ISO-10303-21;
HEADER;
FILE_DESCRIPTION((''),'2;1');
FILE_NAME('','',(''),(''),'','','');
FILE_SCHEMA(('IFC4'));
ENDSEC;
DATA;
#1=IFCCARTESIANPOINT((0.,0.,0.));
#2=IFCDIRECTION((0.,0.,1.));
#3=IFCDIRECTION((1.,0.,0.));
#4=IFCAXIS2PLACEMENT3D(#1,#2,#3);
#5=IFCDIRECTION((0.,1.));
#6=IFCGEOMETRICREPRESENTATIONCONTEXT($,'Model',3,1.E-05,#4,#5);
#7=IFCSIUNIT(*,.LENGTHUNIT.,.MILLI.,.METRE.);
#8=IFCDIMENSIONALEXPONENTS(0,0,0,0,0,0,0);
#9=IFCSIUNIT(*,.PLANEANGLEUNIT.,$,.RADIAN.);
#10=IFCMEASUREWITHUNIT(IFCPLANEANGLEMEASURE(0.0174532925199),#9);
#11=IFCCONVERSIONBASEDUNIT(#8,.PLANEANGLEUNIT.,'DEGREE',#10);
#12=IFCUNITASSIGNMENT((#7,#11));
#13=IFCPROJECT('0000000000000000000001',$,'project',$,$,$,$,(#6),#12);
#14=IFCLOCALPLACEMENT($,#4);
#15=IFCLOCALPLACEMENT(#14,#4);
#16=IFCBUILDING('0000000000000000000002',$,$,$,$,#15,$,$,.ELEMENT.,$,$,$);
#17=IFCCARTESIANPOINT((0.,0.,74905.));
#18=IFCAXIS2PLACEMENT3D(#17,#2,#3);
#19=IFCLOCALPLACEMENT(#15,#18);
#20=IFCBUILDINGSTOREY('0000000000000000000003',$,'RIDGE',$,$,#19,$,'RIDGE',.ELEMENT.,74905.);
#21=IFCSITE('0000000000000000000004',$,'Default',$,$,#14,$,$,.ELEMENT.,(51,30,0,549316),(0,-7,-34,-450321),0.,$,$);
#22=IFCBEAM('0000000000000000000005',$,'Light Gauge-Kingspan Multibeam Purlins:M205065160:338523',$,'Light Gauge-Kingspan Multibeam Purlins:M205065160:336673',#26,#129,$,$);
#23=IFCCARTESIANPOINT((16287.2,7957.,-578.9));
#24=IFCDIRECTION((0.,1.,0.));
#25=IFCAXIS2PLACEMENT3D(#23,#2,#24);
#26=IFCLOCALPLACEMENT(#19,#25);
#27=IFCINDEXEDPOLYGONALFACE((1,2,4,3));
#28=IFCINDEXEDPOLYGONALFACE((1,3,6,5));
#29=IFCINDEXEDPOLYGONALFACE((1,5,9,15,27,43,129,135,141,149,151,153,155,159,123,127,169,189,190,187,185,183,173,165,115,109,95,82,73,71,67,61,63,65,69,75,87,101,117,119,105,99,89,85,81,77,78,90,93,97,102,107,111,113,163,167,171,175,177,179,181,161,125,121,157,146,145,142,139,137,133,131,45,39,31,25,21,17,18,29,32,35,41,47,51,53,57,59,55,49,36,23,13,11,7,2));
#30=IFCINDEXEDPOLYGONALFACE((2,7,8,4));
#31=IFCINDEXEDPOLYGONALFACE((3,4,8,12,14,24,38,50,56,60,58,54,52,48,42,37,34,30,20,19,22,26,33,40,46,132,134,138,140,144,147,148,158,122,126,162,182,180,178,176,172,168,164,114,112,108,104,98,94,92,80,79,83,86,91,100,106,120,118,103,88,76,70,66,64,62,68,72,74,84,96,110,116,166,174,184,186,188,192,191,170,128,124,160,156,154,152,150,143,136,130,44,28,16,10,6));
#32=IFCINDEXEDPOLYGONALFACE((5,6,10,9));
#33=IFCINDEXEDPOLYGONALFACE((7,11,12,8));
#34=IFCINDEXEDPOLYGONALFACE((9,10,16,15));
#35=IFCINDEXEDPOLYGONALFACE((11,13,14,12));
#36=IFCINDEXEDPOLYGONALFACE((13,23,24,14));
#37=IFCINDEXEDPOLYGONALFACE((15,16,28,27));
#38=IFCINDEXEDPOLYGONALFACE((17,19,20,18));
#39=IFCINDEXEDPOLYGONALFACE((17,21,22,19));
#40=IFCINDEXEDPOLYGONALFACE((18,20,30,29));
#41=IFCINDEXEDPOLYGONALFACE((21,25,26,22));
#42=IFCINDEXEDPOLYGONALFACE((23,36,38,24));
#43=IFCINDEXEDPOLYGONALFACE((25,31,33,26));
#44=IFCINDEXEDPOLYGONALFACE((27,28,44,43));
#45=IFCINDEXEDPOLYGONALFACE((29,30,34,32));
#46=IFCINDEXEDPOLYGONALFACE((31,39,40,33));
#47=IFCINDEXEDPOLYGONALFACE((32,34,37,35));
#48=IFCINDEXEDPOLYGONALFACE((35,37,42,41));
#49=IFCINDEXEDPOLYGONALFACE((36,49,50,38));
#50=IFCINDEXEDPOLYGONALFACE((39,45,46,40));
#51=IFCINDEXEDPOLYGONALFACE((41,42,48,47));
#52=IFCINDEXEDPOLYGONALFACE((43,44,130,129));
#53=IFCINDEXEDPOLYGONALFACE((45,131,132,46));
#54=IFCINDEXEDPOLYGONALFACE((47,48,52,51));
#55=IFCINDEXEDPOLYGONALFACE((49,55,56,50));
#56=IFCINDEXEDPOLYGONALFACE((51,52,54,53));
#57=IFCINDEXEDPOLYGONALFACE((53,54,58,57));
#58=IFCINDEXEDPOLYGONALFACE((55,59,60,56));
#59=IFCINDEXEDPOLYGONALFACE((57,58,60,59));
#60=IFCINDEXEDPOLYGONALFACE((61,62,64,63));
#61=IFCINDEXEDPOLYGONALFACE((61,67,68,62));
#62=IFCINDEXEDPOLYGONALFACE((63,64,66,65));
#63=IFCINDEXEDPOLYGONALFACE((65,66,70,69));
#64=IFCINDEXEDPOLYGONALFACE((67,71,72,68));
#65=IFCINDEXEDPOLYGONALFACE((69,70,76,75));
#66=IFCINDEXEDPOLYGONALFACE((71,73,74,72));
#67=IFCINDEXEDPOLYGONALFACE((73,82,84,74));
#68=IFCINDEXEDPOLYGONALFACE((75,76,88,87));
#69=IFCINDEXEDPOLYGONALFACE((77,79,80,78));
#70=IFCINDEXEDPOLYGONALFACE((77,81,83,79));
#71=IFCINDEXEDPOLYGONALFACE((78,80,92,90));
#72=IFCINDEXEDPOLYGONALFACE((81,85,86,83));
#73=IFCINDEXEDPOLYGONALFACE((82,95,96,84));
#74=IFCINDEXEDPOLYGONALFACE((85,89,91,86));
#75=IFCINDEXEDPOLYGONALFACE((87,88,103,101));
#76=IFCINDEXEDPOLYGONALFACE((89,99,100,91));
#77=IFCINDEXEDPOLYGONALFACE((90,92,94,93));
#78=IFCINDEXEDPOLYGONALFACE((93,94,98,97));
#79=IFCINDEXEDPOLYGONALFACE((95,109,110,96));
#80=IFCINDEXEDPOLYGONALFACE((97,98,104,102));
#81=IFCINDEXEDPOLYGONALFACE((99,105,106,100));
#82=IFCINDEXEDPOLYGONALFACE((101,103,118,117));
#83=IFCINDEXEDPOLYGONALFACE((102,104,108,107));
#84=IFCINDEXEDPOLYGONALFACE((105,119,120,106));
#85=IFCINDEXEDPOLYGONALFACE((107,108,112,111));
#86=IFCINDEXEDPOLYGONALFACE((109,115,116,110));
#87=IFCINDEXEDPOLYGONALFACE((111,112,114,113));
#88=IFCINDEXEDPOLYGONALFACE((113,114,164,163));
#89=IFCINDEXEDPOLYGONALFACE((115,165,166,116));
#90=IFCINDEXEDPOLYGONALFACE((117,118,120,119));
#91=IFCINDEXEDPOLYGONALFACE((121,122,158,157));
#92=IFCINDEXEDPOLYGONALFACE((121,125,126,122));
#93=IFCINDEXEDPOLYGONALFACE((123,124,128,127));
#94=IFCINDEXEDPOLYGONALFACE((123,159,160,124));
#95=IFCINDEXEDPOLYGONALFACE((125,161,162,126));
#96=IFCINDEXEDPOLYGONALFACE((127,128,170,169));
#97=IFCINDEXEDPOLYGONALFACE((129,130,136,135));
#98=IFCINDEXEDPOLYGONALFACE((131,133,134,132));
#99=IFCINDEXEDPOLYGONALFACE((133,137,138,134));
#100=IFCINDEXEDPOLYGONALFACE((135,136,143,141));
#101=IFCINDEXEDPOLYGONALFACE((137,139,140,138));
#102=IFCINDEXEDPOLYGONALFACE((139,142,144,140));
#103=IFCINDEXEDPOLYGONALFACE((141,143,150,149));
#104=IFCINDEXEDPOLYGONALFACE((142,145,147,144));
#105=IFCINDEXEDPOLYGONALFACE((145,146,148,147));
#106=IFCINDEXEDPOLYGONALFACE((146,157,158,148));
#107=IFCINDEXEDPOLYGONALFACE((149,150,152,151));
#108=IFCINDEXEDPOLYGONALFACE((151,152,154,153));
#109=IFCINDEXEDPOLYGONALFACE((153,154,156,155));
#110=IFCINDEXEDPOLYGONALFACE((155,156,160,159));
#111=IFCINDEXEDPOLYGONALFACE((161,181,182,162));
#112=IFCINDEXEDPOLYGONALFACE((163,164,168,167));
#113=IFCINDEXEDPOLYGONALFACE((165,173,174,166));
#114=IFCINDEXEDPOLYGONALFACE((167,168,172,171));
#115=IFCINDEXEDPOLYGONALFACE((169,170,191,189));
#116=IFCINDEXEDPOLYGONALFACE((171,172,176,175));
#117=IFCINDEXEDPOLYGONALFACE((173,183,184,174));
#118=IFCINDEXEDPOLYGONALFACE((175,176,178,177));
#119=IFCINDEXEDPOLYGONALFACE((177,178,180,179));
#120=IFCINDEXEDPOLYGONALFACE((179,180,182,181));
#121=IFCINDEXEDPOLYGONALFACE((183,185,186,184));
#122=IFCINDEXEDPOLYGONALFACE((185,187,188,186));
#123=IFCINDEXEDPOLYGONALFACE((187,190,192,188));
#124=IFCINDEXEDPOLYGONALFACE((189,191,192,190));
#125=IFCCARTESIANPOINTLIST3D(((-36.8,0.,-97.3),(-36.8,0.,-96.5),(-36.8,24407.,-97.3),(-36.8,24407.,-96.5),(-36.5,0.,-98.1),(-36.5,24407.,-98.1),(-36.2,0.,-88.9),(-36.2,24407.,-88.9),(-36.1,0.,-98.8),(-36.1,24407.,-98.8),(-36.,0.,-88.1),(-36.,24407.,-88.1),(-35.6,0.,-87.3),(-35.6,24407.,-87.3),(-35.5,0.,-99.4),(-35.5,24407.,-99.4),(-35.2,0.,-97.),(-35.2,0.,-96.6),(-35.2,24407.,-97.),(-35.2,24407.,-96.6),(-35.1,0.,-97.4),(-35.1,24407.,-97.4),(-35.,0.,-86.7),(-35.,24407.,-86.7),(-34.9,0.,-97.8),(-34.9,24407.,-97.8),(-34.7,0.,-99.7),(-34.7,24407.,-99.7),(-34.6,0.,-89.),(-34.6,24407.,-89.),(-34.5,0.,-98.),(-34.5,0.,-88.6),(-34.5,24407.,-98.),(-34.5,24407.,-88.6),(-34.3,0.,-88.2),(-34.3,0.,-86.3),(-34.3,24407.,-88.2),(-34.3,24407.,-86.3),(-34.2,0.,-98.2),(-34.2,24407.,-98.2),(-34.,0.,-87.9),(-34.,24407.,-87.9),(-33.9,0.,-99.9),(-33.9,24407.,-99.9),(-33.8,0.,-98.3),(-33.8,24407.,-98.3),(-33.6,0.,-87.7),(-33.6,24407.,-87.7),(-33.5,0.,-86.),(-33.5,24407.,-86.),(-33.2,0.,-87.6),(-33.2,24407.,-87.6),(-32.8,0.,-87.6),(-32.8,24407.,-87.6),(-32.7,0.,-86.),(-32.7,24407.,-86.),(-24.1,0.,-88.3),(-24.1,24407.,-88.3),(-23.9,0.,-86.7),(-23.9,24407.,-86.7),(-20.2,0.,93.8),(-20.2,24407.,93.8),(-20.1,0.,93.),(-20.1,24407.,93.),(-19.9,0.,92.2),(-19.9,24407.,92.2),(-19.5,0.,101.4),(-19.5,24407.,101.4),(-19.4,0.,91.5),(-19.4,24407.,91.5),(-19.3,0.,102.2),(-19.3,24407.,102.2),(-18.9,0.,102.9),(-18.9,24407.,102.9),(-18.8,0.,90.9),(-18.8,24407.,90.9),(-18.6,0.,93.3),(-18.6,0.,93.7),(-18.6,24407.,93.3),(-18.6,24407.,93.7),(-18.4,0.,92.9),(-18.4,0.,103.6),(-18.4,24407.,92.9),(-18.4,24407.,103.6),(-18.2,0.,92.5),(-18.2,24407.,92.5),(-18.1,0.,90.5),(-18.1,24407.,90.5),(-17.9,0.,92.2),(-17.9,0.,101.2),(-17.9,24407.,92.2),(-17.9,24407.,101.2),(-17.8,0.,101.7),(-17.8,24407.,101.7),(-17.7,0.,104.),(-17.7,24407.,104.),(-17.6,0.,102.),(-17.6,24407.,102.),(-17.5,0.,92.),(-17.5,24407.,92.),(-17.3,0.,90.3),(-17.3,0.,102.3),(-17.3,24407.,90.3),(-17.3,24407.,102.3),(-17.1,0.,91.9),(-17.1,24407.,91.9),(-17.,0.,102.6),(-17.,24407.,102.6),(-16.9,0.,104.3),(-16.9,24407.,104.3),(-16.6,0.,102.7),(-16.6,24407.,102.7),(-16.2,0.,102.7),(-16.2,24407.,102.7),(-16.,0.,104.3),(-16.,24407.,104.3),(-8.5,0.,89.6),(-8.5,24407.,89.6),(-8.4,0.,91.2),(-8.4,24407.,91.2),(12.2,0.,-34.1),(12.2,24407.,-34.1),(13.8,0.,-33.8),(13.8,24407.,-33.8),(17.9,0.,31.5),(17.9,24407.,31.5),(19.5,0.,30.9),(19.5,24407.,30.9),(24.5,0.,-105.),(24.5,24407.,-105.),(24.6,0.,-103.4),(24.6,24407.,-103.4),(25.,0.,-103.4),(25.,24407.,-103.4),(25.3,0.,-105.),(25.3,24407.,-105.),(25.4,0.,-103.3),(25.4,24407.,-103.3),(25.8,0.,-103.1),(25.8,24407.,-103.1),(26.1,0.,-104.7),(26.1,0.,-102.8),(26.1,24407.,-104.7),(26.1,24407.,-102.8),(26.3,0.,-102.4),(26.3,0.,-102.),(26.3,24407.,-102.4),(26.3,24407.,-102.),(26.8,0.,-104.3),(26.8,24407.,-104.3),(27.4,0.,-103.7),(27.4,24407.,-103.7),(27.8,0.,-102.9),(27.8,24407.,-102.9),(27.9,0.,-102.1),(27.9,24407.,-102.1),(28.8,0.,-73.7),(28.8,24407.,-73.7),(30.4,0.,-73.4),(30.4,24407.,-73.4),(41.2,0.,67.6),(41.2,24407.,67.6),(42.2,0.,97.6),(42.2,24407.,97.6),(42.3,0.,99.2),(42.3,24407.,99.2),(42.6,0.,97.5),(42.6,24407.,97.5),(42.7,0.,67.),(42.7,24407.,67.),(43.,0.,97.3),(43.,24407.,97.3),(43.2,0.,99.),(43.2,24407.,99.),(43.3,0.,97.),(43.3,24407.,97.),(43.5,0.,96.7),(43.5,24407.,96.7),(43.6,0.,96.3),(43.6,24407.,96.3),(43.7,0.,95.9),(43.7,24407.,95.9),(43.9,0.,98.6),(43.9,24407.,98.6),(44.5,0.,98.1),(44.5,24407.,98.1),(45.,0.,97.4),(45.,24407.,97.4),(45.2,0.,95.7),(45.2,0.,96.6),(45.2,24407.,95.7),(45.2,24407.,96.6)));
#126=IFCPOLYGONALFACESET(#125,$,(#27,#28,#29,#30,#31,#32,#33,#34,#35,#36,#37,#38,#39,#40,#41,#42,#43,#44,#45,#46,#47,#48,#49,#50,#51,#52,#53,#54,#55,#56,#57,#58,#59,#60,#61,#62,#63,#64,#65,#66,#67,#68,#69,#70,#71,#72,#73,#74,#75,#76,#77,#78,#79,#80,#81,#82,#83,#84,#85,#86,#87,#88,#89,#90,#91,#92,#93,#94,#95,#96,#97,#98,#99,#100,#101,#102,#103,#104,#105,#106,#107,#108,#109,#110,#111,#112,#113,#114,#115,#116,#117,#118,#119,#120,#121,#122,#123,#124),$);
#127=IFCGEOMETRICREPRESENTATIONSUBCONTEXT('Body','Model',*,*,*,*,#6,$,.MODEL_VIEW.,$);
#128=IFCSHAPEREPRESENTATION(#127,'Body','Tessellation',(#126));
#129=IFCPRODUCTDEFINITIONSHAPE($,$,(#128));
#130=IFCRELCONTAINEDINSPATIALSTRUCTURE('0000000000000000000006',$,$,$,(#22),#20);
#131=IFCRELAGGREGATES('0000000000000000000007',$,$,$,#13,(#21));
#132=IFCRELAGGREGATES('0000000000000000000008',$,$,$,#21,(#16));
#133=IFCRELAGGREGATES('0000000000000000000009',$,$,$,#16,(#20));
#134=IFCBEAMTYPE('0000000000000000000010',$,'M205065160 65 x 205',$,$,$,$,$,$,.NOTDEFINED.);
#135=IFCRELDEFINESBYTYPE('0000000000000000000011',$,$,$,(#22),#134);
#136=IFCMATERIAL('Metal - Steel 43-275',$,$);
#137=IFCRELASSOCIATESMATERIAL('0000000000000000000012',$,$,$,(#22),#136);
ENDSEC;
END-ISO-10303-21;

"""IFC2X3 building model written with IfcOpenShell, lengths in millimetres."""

from ifc_helpers import new_model, entity, si_unit, converted_unit, point, direction, frame, frame_2d, origin_with_axes, place, context, subcontext, project, spatial, polyline, circle_curve, parameter, trimmed, segment, composite_curve, outline, extrude, material, type_object, element, save


model = new_model("IFC2X3")

# Units and contexts
model_context = context("Model", 3, precision=1e-05, world=origin_with_axes(), true_north=direction((0.0, 1.0)))
body_context = subcontext(model_context, "Body", "Model", "MODEL_VIEW")
ifc_project = project(units=[si_unit("LENGTHUNIT", "METRE", prefix="MILLI"), converted_unit("PLANEANGLEUNIT", "DEGREE", entity("IfcPlaneAngleMeasure", 0.0174532925199), si_unit("PLANEANGLEUNIT", "RADIAN"), dimensions=[0, 0, 0, 0, 0, 0, 0])], contexts=[model_context])

# Site, building, storey
site_placement = place(None, origin_with_axes())
site = spatial("IfcSite", under=ifc_project, at=site_placement, Name="Default", CompositionType="ELEMENT", RefLatitude=(51, 30, 0, 549316), RefLongitude=(0, -7, -34, -450321), RefElevation=0.0)
building_placement = place(site_placement, origin_with_axes())
building = spatial("IfcBuilding", under=site, at=building_placement, CompositionType="ELEMENT")
storey_placement = place(building_placement, frame((0.0, 0.0, 74905.0), z_axis=(0.0, 0.0, 1.0), x_axis=(1.0, 0.0, 0.0)))
storey = spatial("IfcBuildingStorey", under=building, at=storey_placement, Name="RIDGE", LongName="RIDGE", CompositionType="ELEMENT", Elevation=74905.0)

# Beam
ifc_material_1 = material(Name="Metal - Steel 43-275")
beam_type_1 = type_object("IfcBeamType", Name="M205065160 65 x 205", PredefinedType="NOTDEFINED")
beam_1_placement = place(storey_placement, frame((16287.2, 7957.0, -578.9), z_axis=(0.0, 0.0, 1.0), x_axis=(0.0, 1.0, 0.0)))
element("IfcBeam", 1, at=beam_1_placement, inside=storey, type_object=beam_type_1, material=ifc_material_1, Name="Light Gauge-Kingspan Multibeam Purlins:M205065160:338523", ObjectType="Light Gauge-Kingspan Multibeam Purlins:M205065160:336673", context=body_context, shape_type="SweptSolid", body=[
    extrude(outline(composite_curve([segment(polyline([(-33.5, -102.5), (25.1, -102.5)]), True, "CONTINUOUS"), segment(trimmed(circle_curve(frame_2d((25.1, -99.3), x_axis=(0.0, -1.0)), 3.2), [point((25.1, -102.5)), parameter(0.0)], [point((28.3, -99.3)), parameter(90.0)], True, "CARTESIAN"), True, "CONTINUOUS"), segment(polyline([(28.3, -99.3), (28.3, -91.7)]), True, "CONTINUOUS"), segment(trimmed(circle_curve(frame_2d((25.1, -91.7), x_axis=(1.0, 0.0)), 3.2), [point((28.3, -91.7)), parameter(0.0)], [point((25.1, -88.5)), parameter(90.0)], True, "CARTESIAN"), True, "CONTINUOUS"), segment(polyline([(25.1, -88.5), (16.3, -88.5), (16.3, -90.1), (25.1, -90.1)]), True, "CONTINUOUS"), segment(trimmed(circle_curve(frame_2d((25.1, -91.7), x_axis=(1.0, 0.0)), 1.6), [point((25.1, -90.1)), parameter(90.0)], [point((26.7, -91.7)), parameter(0.0)], False, "CARTESIAN"), True, "CONTINUOUS"), segment(polyline([(26.7, -91.7), (26.7, -99.3)]), True, "CONTINUOUS"), segment(trimmed(circle_curve(frame_2d((25.1, -99.3), x_axis=(0.0, -1.0)), 1.6), [point((26.7, -99.3)), parameter(90.0)], [point((25.1, -100.9)), parameter(0.0)], False, "CARTESIAN"), True, "CONTINUOUS"), segment(polyline([(25.1, -100.9), (-33.5, -100.9)]), True, "CONTINUOUS"), segment(trimmed(circle_curve(frame_2d((-33.5, -99.3), x_axis=(-1.0, 0.0)), 1.6), [point((-33.5, -100.9)), parameter(90.0)], [point((-35.1, -99.3)), parameter(0.0)], False, "CARTESIAN"), True, "CONTINUOUS"), segment(polyline([(-35.1, -99.3), (-35.1, -70.9), (-15.1, -32.9), (-15.1, 32.9), (-35.1, 70.9), (-35.1, 99.3)]), True, "CONTINUOUS"), segment(trimmed(circle_curve(frame_2d((-33.5, 99.3), x_axis=(0.0, 1.0)), 1.6), [point((-35.1, 99.3)), parameter(90.0)], [point((-33.5, 100.9)), parameter(0.0)], False, "CARTESIAN"), True, "CONTINUOUS"), segment(polyline([(-33.5, 100.9), (25.1, 100.9)]), True, "CONTINUOUS"), segment(trimmed(circle_curve(frame_2d((25.1, 99.3), x_axis=(1.0, 0.0)), 1.6), [point((25.1, 100.9)), parameter(90.0)], [point((26.7, 99.3)), parameter(0.0)], False, "CARTESIAN"), True, "CONTINUOUS"), segment(polyline([(26.7, 99.3), (26.7, 91.7)]), True, "CONTINUOUS"), segment(trimmed(circle_curve(frame_2d((25.1, 91.7), x_axis=(0.0, -1.0)), 1.6), [point((26.7, 91.7)), parameter(90.0)], [point((25.1, 90.1)), parameter(0.0)], False, "CARTESIAN"), True, "CONTINUOUS"), segment(polyline([(25.1, 90.1), (16.3, 90.1), (16.3, 88.5), (25.1, 88.5)]), True, "CONTINUOUS"), segment(trimmed(circle_curve(frame_2d((25.1, 91.7), x_axis=(0.0, -1.0)), 3.2), [point((25.1, 88.5)), parameter(0.0)], [point((28.3, 91.7)), parameter(90.0)], True, "CARTESIAN"), True, "CONTINUOUS"), segment(polyline([(28.3, 91.7), (28.3, 99.3)]), True, "CONTINUOUS"), segment(trimmed(circle_curve(frame_2d((25.1, 99.3), x_axis=(1.0, 0.0)), 3.2), [point((28.3, 99.3)), parameter(0.0)], [point((25.1, 102.5)), parameter(90.0)], True, "CARTESIAN"), True, "CONTINUOUS"), segment(polyline([(25.1, 102.5), (-33.5, 102.5)]), True, "CONTINUOUS"), segment(trimmed(circle_curve(frame_2d((-33.5, 99.3), x_axis=(0.0, 1.0)), 3.2), [point((-33.5, 102.5)), parameter(0.0)], [point((-36.7, 99.3)), parameter(90.0)], True, "CARTESIAN"), True, "CONTINUOUS"), segment(polyline([(-36.7, 99.3), (-36.7, 70.5), (-16.7, 32.5), (-16.7, -32.5), (-36.7, -70.5), (-36.7, -99.3)]), True, "CONTINUOUS"), segment(trimmed(circle_curve(frame_2d((-33.5, -99.3), x_axis=(-1.0, 0.0)), 3.2), [point((-36.7, -99.3)), parameter(0.0)], [point((-33.5, -102.5)), parameter(90.0)], True, "CARTESIAN"), True, "CONTINUOUS")], self_intersect=False)), frame((0.0, 24407.0, 0.0), z_axis=(0.0, -1.0, 0.0), x_axis=(-0.996195, 0.0, 0.087156)), (0.0, 0.0, 1.0), 24407.0),
])

save(model, "model.ifc")
